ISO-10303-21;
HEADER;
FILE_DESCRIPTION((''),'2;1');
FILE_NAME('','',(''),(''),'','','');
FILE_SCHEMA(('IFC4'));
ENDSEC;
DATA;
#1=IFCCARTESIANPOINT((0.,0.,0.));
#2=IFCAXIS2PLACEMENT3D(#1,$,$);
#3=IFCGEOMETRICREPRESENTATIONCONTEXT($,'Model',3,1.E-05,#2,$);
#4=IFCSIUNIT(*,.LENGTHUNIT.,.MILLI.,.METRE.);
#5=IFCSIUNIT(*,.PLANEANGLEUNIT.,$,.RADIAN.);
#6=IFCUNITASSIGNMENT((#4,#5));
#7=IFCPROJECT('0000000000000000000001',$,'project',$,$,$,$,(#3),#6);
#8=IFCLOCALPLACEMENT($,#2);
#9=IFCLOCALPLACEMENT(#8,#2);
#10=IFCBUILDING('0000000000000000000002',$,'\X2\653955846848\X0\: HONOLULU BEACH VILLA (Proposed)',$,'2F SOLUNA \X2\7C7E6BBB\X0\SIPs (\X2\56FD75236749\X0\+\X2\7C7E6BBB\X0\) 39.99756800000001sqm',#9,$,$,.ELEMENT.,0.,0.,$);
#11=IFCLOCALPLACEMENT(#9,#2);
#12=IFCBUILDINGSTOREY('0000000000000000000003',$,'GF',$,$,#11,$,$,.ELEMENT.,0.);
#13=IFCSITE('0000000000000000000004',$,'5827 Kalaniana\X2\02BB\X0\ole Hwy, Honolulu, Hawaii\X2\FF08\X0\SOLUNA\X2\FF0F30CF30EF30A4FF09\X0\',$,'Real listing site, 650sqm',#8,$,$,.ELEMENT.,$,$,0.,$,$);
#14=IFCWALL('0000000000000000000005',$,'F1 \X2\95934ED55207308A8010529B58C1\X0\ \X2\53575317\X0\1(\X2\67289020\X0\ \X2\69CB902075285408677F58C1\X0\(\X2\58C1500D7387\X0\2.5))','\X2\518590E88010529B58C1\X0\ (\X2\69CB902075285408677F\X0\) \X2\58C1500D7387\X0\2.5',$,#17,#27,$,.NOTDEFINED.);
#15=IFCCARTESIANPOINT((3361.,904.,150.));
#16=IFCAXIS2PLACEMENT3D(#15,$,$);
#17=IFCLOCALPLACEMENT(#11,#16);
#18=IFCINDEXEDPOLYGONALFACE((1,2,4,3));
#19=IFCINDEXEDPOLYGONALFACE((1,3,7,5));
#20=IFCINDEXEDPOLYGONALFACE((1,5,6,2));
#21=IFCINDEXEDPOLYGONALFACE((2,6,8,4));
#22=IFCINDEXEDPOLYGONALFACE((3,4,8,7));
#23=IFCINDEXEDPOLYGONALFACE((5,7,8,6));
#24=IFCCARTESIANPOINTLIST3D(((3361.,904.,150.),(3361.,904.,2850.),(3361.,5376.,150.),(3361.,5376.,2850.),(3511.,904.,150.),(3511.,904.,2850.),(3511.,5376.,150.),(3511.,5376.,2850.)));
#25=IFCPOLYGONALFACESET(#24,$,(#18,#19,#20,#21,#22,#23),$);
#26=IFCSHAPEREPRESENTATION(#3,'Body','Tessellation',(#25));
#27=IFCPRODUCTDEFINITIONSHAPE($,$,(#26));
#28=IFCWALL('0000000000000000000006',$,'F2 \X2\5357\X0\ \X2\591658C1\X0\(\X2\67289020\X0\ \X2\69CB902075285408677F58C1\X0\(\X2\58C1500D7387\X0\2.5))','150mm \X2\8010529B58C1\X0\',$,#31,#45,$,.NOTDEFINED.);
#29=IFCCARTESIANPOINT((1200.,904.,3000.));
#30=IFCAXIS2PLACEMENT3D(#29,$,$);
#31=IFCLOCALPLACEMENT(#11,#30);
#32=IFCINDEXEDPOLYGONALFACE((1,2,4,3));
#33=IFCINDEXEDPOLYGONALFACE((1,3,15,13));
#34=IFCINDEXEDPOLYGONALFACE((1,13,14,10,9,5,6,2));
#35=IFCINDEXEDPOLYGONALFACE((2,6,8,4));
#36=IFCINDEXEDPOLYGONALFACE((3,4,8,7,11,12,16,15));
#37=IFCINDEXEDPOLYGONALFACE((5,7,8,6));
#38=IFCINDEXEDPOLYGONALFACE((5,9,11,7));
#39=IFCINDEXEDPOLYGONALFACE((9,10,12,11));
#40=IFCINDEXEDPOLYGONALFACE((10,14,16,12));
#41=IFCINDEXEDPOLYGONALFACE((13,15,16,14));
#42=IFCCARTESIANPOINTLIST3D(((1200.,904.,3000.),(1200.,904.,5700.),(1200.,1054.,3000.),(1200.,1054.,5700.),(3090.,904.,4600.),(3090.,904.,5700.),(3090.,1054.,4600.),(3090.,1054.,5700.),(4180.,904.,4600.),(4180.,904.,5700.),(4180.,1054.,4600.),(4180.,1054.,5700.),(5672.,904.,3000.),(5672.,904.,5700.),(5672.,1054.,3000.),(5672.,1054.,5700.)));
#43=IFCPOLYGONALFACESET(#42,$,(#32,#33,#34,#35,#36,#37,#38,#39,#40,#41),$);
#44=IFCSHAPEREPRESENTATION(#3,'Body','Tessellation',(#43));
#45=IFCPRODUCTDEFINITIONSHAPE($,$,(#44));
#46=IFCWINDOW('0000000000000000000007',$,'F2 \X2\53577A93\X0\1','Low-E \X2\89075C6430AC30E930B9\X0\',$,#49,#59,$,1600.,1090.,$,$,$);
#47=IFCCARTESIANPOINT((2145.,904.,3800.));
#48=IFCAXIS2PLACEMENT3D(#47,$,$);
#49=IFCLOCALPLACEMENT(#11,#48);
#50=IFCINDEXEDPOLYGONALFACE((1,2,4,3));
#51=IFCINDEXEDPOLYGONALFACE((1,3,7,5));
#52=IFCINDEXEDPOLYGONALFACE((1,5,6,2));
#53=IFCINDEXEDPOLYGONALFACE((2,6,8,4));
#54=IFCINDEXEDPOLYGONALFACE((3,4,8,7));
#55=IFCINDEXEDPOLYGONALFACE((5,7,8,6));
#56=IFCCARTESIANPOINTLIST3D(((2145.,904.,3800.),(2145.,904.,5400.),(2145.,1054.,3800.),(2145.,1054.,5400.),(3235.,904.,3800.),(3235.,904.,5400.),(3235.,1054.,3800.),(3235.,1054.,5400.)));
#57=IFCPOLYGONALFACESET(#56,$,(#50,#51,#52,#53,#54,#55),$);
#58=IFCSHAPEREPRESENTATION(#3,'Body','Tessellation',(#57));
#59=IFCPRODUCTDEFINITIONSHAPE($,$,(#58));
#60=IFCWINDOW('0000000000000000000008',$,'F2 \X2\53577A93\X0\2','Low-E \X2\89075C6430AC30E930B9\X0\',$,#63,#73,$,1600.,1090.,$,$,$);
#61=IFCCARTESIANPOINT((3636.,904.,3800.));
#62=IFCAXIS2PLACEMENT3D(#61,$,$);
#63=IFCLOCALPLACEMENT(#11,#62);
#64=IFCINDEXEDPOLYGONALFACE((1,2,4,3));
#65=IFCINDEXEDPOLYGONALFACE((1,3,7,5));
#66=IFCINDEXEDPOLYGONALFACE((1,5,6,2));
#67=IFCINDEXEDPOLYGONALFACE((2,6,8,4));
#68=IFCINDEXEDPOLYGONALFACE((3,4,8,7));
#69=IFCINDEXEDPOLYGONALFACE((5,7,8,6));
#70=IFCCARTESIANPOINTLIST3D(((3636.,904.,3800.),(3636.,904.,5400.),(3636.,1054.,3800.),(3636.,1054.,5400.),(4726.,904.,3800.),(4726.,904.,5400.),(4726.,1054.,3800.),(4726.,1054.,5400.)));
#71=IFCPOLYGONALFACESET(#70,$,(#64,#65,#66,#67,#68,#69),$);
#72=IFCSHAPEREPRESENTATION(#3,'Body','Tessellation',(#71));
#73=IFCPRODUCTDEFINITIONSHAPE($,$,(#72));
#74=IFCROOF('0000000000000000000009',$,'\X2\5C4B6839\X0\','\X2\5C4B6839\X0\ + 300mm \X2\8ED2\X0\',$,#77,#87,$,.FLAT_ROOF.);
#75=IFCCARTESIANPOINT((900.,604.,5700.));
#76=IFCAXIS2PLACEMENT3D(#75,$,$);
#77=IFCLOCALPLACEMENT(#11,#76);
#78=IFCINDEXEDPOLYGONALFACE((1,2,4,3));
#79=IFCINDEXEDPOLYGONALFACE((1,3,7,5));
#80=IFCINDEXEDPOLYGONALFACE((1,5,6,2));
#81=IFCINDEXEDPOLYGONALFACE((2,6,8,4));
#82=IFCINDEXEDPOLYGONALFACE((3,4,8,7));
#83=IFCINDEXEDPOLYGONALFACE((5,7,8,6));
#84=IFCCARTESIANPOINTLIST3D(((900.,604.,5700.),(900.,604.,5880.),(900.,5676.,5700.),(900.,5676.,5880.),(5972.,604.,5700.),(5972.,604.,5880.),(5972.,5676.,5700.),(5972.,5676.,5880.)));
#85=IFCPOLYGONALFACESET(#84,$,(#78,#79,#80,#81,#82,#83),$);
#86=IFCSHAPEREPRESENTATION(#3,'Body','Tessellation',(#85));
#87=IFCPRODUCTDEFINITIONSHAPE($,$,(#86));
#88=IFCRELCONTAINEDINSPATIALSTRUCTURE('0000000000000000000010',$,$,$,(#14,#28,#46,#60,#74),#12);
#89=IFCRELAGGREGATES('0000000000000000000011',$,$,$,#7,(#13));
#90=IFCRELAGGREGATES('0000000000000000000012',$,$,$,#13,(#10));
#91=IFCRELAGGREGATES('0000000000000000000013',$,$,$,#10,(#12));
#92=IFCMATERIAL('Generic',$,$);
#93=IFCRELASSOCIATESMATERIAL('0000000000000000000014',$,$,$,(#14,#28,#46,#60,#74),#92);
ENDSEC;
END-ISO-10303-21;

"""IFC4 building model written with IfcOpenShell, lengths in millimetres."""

from ifc_helpers import new_model, si_unit, frame, frame_2d, origin, place, context, project, spatial, rectangle, extrude, material, element, fill, save


model = new_model("IFC4")

# Units and contexts
model_context = context("Model", 3, precision=1e-05, world=origin())
ifc_project = project(units=[si_unit("LENGTHUNIT", "METRE", prefix="MILLI"), si_unit("PLANEANGLEUNIT", "RADIAN")], contexts=[model_context])

# Site, building, storey
site_placement = place(None, origin())
site = spatial("IfcSite", under=ifc_project, at=site_placement, Name="5827 Kalanianaʻole Hwy, Honolulu, Hawaii（SOLUNA／ハワイ）", ObjectType="Real listing site, 650sqm", CompositionType="ELEMENT", RefElevation=0.0)
building_placement = place(site_placement, origin())
building = spatial("IfcBuilding", under=site, at=building_placement, Name="改善案: HONOLULU BEACH VILLA (Proposed)", ObjectType="2F SOLUNA 籾殻SIPs (国産杉+籾殻) 39.99756800000001sqm", CompositionType="ELEMENT", ElevationOfRefHeight=0.0, ElevationOfTerrain=0.0)
storey_placement = place(building_placement, origin())
storey = spatial("IfcBuildingStorey", under=building, at=storey_placement, Name="GF", CompositionType="ELEMENT", Elevation=0.0)

# Shared definitions
ifc_material_1 = material(Name="Generic")

# Wall
wall_1_placement = place(storey_placement, frame((3361.0, 904.0, 150.0)))
element("IfcWall", 1, at=wall_1_placement, inside=storey, material=ifc_material_1, Name="F1 間仕切り耐力壁 南北1(木造 構造用合板壁(壁倍率2.5))", Description="内部耐力壁 (構造用合板) 壁倍率2.5", PredefinedType="NOTDEFINED", context=model_context, shape_type="SweptSolid", body=[
    extrude(rectangle(XDim=150.0, YDim=4472.0, at=frame_2d((75.0, 2236.0))), frame((3361.0, 904.0, 150.0)), (0.0, 0.0, 1.0), 2700.0),
])

# Wall, openings, windows
wall_2_placement = place(storey_placement, frame((1200.0, 904.0, 3000.0)))
wall_2 = element("IfcWall", 2, at=wall_2_placement, inside=storey, material=ifc_material_1, Name="F2 南 外壁(木造 構造用合板壁(壁倍率2.5))", Description="150mm 耐力壁", PredefinedType="NOTDEFINED", context=model_context, shape_type="SweptSolid", body=[
    extrude(rectangle(XDim=4472.0, YDim=150.0, at=frame_2d((2236.0, 75.0))), frame((1200.0, 904.0, 3000.0)), (0.0, 0.0, 1.0), 2700.0),
])
opening_1_placement = place(storey_placement, frame((2145.0, 904.0, 3800.0)))
opening_1 = element("IfcOpeningElement", 3, at=opening_1_placement, cuts=wall_2, PredefinedType="NOTDEFINED", context=model_context, shape_type="SweptSolid", body=[
    extrude(rectangle(XDim=1090.0, YDim=150.0, at=frame_2d((545.0, 75.0))), frame((2145.0, 904.0, 3800.0)), (0.0, 0.0, 1.0), 1600.0),
])
opening_2_placement = place(storey_placement, frame((3636.0, 904.0, 3800.0)))
opening_2 = element("IfcOpeningElement", 4, at=opening_2_placement, cuts=wall_2, PredefinedType="NOTDEFINED", context=model_context, shape_type="SweptSolid", body=[
    extrude(rectangle(XDim=1090.0, YDim=150.0, at=frame_2d((545.0, 75.0))), frame((3636.0, 904.0, 3800.0)), (0.0, 0.0, 1.0), 1600.0),
])
window_1_placement = place(storey_placement, frame((2145.0, 904.0, 3800.0)))
window_1 = element("IfcWindow", 5, at=window_1_placement, inside=storey, material=ifc_material_1, Name="F2 南窓1", Description="Low-E 複層ガラス", OverallHeight=1600.0, OverallWidth=1090.0, context=model_context, shape_type="SweptSolid", body=[
    extrude(rectangle(XDim=1090.0, YDim=150.0, at=frame_2d((545.0, 75.0))), frame((2145.0, 904.0, 3800.0)), (0.0, 0.0, 1.0), 1600.0),
])
fill(opening_1, window_1)
window_2_placement = place(storey_placement, frame((3636.0, 904.0, 3800.0)))
window_2 = element("IfcWindow", 6, at=window_2_placement, inside=storey, material=ifc_material_1, Name="F2 南窓2", Description="Low-E 複層ガラス", OverallHeight=1600.0, OverallWidth=1090.0, context=model_context, shape_type="SweptSolid", body=[
    extrude(rectangle(XDim=1090.0, YDim=150.0, at=frame_2d((545.0, 75.0))), frame((3636.0, 904.0, 3800.0)), (0.0, 0.0, 1.0), 1600.0),
])
fill(opening_2, window_2)

# Roof
roof_placement = place(storey_placement, frame((900.0, 604.0, 5700.0)))
element("IfcRoof", 7, at=roof_placement, inside=storey, material=ifc_material_1, Name="屋根", Description="屋根 + 300mm 軒", PredefinedType="FLAT_ROOF", context=model_context, shape_type="SweptSolid", body=[
    extrude(rectangle(XDim=5072.0, YDim=5072.0, at=frame_2d((2536.0, 2536.0))), frame((900.0, 604.0, 5700.0)), (0.0, 0.0, 1.0), 180.0),
])

save(model, "model.ifc")
